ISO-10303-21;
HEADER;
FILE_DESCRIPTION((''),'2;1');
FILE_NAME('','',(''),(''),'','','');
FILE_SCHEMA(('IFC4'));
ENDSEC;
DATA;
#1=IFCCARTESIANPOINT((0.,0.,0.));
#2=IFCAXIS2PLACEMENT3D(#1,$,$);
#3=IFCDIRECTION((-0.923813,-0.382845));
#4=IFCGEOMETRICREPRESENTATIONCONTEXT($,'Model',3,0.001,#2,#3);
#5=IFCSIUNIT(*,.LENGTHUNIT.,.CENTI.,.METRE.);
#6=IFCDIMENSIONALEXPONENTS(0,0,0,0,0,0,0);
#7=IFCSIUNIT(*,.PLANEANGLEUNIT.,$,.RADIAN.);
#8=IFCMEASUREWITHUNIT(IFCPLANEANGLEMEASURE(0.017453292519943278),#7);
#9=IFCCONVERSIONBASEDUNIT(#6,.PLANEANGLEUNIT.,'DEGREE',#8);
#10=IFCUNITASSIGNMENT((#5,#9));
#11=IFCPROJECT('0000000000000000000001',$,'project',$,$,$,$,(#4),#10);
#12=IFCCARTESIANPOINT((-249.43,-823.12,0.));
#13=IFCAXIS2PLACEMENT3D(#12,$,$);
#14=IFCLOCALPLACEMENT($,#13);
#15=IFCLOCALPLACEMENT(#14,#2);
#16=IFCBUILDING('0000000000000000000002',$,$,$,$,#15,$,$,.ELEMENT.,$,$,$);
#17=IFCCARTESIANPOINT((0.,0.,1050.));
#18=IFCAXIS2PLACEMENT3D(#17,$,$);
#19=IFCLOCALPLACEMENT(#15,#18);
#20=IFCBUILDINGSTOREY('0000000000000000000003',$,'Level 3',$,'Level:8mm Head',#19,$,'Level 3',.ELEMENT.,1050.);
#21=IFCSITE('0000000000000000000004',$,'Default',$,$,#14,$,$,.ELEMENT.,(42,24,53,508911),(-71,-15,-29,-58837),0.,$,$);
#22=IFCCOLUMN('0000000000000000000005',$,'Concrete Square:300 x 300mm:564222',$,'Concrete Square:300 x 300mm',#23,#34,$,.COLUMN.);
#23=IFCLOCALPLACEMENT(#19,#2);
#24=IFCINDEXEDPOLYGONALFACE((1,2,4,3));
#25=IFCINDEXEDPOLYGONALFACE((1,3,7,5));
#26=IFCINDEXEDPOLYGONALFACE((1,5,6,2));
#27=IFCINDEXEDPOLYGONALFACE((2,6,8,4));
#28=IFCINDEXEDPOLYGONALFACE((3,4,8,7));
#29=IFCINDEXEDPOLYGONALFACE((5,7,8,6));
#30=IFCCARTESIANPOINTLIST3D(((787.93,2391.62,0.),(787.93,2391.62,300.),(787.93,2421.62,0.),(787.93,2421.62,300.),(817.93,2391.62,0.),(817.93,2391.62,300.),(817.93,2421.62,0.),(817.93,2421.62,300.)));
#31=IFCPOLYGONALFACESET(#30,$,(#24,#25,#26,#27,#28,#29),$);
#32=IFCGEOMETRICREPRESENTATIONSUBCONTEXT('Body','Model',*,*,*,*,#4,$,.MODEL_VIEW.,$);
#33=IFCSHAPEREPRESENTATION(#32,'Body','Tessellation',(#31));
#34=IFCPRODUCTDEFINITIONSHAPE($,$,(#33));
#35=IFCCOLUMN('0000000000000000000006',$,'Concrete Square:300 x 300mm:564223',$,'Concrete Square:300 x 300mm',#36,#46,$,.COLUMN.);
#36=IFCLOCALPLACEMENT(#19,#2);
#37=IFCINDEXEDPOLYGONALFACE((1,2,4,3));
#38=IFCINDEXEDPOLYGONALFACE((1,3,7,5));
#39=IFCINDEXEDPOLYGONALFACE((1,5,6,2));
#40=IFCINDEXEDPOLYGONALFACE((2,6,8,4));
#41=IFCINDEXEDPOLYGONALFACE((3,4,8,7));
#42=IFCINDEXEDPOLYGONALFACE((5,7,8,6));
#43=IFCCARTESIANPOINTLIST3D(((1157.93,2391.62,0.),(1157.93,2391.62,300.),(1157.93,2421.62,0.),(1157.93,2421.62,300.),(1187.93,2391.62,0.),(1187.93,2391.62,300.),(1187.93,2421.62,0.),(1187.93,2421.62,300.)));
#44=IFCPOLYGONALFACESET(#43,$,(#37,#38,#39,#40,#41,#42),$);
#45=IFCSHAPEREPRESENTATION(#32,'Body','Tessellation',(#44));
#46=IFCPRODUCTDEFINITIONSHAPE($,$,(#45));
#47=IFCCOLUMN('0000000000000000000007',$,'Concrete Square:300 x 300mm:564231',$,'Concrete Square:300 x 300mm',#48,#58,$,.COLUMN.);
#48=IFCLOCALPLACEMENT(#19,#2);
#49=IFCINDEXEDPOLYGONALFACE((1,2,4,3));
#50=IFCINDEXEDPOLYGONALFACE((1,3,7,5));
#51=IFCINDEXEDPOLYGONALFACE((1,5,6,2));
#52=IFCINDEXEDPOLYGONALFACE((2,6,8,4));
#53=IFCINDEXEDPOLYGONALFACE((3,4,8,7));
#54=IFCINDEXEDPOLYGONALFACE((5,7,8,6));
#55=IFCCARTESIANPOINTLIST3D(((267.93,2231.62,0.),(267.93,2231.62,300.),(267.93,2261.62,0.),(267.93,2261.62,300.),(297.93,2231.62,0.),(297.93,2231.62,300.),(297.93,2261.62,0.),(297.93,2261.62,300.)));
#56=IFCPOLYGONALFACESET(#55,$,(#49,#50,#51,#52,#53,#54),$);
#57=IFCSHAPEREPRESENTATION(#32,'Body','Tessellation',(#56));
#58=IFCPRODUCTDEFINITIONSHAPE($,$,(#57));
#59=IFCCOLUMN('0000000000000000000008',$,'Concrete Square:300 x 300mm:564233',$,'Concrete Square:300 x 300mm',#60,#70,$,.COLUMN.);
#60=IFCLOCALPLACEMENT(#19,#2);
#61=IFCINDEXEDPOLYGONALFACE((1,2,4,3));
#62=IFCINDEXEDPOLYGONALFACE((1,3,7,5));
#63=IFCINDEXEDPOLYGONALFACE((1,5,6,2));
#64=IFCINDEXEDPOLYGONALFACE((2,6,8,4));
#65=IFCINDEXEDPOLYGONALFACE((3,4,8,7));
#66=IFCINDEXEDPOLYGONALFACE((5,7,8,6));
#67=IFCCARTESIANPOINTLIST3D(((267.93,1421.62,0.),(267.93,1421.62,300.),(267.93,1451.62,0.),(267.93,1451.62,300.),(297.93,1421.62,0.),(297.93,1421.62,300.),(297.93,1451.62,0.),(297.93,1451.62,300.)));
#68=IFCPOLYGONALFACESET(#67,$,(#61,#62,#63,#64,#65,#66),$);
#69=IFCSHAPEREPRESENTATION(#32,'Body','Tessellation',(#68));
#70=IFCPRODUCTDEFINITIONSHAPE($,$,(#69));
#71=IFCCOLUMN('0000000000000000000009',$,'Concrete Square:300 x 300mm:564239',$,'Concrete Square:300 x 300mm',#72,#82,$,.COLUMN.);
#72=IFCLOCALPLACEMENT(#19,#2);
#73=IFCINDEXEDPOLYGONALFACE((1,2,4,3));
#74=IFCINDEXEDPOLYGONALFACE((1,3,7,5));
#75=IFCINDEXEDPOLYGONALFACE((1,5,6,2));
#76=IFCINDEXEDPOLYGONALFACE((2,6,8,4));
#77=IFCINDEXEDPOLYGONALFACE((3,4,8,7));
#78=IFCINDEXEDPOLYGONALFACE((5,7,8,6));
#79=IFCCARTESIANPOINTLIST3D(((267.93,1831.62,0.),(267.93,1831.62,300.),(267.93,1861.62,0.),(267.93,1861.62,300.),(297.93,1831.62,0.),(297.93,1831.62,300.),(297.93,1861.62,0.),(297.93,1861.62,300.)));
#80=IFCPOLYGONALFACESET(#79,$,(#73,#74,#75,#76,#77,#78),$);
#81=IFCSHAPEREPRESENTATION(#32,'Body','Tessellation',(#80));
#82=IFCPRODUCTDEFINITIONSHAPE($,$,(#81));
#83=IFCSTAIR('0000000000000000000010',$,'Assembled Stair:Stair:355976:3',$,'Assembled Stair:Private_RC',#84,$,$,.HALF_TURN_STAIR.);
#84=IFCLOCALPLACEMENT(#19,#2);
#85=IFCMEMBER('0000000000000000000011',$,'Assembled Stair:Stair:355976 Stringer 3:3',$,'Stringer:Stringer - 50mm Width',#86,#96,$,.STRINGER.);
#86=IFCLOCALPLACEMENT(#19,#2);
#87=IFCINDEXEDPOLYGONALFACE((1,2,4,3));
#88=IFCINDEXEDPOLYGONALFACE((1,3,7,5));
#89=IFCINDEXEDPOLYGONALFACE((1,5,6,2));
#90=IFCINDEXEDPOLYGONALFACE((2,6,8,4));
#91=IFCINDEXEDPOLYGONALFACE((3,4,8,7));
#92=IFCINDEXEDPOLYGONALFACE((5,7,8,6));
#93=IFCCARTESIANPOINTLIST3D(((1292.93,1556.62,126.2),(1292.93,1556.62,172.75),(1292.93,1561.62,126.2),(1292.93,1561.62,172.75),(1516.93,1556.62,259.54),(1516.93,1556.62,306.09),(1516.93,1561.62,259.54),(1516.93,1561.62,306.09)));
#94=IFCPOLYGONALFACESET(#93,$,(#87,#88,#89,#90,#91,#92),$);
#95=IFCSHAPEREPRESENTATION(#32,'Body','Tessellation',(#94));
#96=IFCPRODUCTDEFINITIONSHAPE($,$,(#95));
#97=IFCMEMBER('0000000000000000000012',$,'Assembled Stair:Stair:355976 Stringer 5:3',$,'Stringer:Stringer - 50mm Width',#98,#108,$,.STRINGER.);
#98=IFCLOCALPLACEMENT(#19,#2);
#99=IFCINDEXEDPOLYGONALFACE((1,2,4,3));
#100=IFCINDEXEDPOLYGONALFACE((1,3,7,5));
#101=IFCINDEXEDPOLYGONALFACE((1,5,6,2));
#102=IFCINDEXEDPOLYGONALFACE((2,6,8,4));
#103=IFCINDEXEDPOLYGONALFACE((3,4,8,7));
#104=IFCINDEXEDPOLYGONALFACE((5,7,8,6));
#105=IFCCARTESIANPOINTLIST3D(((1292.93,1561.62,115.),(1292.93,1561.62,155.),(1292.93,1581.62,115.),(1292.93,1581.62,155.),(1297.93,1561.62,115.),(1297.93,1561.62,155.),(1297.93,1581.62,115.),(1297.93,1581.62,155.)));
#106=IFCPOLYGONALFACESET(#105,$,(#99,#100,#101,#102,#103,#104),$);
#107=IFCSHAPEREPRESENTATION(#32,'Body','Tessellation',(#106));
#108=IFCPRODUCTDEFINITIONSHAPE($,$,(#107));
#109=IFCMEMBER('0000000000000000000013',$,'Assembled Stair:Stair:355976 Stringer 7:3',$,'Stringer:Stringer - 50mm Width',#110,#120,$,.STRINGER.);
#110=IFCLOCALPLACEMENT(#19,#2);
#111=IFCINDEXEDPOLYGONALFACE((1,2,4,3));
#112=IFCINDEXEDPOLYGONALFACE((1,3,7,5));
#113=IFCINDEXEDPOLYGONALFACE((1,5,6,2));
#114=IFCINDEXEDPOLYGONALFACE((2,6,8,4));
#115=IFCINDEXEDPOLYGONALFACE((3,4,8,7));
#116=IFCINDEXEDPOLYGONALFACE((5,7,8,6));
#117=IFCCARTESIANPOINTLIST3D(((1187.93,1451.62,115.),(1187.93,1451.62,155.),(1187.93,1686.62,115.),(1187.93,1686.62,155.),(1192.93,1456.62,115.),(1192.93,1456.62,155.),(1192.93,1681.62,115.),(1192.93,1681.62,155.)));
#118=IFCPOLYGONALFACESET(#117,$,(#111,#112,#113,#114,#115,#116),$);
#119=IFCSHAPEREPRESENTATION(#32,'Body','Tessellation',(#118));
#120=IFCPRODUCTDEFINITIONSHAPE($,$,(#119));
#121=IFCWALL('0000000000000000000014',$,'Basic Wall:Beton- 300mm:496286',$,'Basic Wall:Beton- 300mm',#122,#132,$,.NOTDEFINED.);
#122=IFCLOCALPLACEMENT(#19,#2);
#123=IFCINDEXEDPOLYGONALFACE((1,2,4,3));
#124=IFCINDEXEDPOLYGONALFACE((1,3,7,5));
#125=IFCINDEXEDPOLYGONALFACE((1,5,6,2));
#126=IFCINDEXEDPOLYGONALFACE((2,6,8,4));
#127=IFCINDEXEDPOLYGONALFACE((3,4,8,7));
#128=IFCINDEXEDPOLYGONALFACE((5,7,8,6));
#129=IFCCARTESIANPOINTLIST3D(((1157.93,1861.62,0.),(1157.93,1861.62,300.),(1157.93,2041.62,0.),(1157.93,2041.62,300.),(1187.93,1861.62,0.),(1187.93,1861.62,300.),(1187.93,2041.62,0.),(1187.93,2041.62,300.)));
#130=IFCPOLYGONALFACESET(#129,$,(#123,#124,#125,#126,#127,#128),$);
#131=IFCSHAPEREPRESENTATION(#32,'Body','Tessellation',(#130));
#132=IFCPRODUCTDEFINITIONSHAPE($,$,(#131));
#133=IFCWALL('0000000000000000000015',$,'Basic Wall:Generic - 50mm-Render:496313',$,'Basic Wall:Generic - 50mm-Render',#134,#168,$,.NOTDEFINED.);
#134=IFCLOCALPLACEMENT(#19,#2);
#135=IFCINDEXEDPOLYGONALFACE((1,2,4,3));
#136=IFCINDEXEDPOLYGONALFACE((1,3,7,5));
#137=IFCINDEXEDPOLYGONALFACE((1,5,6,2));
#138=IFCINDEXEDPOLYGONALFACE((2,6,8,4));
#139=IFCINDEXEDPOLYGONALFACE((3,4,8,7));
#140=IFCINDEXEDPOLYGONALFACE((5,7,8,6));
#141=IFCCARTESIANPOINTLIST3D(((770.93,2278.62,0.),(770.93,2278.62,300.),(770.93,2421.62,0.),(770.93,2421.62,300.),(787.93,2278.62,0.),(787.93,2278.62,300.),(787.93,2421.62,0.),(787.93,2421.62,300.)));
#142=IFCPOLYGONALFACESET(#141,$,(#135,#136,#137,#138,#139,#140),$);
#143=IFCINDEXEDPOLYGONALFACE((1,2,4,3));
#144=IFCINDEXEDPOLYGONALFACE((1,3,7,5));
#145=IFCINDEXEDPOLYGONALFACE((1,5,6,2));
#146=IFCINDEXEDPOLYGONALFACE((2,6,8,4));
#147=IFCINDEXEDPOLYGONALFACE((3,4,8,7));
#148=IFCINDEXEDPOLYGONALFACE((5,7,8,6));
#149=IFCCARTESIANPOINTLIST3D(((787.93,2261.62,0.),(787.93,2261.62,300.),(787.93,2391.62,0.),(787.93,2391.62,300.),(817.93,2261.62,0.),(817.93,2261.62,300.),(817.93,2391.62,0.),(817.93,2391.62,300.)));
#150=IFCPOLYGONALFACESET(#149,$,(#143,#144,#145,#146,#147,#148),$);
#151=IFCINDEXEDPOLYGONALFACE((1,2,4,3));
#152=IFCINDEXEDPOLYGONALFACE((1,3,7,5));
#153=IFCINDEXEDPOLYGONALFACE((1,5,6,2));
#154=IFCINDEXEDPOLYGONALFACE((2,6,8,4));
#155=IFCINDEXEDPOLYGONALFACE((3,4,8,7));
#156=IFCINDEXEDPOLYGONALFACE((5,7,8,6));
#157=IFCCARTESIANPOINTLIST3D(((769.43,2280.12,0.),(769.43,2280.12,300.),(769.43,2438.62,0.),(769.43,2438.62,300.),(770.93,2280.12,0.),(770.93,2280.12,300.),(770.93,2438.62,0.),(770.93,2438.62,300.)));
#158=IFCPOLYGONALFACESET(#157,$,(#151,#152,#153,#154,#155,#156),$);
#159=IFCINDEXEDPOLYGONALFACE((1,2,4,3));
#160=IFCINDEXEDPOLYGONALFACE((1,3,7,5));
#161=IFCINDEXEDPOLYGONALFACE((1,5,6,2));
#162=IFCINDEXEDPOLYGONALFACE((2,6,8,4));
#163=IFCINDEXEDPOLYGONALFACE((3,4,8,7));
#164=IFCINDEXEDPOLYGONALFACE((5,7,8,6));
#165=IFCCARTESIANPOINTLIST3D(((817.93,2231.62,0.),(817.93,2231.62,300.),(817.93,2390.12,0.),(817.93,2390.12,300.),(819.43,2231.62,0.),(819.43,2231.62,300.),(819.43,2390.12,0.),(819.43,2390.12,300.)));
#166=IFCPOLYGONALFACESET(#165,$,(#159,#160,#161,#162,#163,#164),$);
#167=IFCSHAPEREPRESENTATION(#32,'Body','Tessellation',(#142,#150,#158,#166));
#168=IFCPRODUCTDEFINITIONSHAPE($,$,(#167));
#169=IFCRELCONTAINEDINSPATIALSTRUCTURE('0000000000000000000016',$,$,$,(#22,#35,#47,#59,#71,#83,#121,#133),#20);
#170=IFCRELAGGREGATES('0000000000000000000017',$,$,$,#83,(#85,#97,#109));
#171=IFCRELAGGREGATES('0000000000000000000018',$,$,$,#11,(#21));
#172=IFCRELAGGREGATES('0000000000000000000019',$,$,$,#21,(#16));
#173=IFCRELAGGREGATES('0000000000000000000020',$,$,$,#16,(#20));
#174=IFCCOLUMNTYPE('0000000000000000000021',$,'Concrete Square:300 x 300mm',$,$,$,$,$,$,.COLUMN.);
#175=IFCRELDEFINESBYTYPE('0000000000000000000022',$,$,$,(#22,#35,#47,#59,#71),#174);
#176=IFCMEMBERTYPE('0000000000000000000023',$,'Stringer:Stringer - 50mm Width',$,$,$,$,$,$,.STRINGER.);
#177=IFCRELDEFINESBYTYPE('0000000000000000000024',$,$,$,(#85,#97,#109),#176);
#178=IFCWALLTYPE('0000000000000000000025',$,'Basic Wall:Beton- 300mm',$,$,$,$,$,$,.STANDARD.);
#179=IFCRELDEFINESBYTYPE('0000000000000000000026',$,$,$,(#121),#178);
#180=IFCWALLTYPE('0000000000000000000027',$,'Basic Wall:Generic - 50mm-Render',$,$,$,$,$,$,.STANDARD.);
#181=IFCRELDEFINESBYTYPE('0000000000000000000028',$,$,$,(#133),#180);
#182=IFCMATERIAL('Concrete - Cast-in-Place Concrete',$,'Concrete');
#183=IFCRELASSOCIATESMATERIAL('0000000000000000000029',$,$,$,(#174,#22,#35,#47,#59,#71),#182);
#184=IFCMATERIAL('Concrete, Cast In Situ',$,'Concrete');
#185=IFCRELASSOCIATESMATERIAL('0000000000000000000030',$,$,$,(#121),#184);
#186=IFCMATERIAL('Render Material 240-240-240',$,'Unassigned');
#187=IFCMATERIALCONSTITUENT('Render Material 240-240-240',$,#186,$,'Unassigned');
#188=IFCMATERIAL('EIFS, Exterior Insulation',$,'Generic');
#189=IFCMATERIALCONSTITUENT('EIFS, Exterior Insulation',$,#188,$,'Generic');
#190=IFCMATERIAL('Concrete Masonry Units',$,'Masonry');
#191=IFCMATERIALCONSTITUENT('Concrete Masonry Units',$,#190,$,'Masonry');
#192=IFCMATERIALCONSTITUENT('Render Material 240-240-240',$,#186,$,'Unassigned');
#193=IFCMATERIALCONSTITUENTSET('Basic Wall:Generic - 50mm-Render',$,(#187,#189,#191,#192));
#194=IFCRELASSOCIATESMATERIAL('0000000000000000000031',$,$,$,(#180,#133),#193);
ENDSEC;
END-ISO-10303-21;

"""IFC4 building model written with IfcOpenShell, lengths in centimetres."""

from ifc_helpers import new_model, entity, si_unit, converted_unit, direction, frame, origin, place, context, subcontext, project, spatial, indexed_curve, outline, extrude, source, transform, mapped, material, constituent, constituent_set, type_object, type_shapes, element, aggregate, save


model = new_model("IFC4")

# Units and contexts
model_context = context("Model", 3, precision=0.001, world=origin(), true_north=direction((-0.923813, -0.382845)))
body_context = subcontext(model_context, "Body", "Model", "MODEL_VIEW")
ifc_project = project(units=[si_unit("LENGTHUNIT", "METRE", prefix="CENTI"), converted_unit("PLANEANGLEUNIT", "DEGREE", entity("IfcPlaneAngleMeasure", 0.017453292519943278), si_unit("PLANEANGLEUNIT", "RADIAN"), dimensions=[0, 0, 0, 0, 0, 0, 0])], contexts=[model_context])

# Site, building, storey
site_placement = place(None, frame((-249.43, -823.12, 0.0)))
site = spatial("IfcSite", under=ifc_project, at=site_placement, Name="Default", CompositionType="ELEMENT", RefLatitude=(42, 24, 53, 508911), RefLongitude=(-71, -15, -29, -58837), RefElevation=0.0)
building_placement = place(site_placement, origin())
building = spatial("IfcBuilding", under=site, at=building_placement, CompositionType="ELEMENT")
storey_placement = place(building_placement, frame((0.0, 0.0, 1050.0)))
storey = spatial("IfcBuildingStorey", under=building, at=storey_placement, Name="Level 3", ObjectType="Level:8mm Head", LongName="Level 3", CompositionType="ELEMENT", Elevation=1050.0)

# Columns
ifc_material_1 = material(Name="Concrete - Cast-in-Place Concrete", Category="Concrete")
column_type = type_object("IfcColumnType", Name="Concrete Square:300 x 300mm", PredefinedType="COLUMN", material=ifc_material_1)
shared_shape_1 = source(origin(), body_context, "Body", "SweptSolid", [
    extrude(outline(indexed_curve([(-15.0, -15.0), (15.0, -15.0), (15.0, 15.0), (-15.0, 15.0), (-15.0, -15.0)], self_intersect=False)), frame((0.0, 0.0, 1050.0), z_axis=(0.0, 0.0, 1.0), x_axis=(-1.0, 0.0, 0.0)), (0.0, 0.0, 1.0), 300.0),
])
type_shapes(column_type, [shared_shape_1])
for number, where, name in (
    (1, (802.93, 2406.62, -1050.0), "Concrete Square:300 x 300mm:564222"),
    (2, (1172.93, 2406.62, -1050.0), "Concrete Square:300 x 300mm:564223"),
    (3, (282.93, 2246.62, -1050.0), "Concrete Square:300 x 300mm:564231"),
    (4, (282.93, 1436.62, -1050.0), "Concrete Square:300 x 300mm:564233"),
    (5, (282.93, 1846.62, -1050.0), "Concrete Square:300 x 300mm:564239"),
):
    element("IfcColumn", number, at=place(storey_placement, frame(where)), inside=storey, type_object=column_type, material=ifc_material_1, Name=name, ObjectType="Concrete Square:300 x 300mm", PredefinedType="COLUMN", context=body_context, shape_type="MappedRepresentation", body=[
        mapped(shared_shape_1, transform((0.0, 0.0, 0.0), scale=1.0)),
    ])

# Stair, members
stair_placement = place(storey_placement, origin())
stair = element("IfcStair", 6, at=stair_placement, inside=storey, Name="Assembled Stair:Stair:355976:3", ObjectType="Assembled Stair:Private_RC", PredefinedType="HALF_TURN_STAIR")
member_type = type_object("IfcMemberType", Name="Stringer:Stringer - 50mm Width", PredefinedType="STRINGER")
member_1_placement = place(stair_placement, frame((1292.93, 1556.62, 126.2)))
member_1 = element("IfcMember", 7, at=member_1_placement, type_object=member_type, Name="Assembled Stair:Stair:355976 Stringer 3:3", ObjectType="Stringer:Stringer - 50mm Width", PredefinedType="STRINGER", context=body_context, shape_type="SweptSolid", body=[
    extrude(outline(indexed_curve([(-118.43, -20.0), (142.24, -20.0), (118.43, 20.0), (-142.24, 20.0), (-118.43, -20.0)], self_intersect=False)), frame((112.0, 0.0, 89.94), z_axis=(0.0, 1.0, 0.0), x_axis=(0.859293, 0.0, 0.511484)), (0.0, 0.0, 1.0), 5.0),
])
member_2_placement = place(stair_placement, frame((1292.93, 1561.62, 115.0)))
member_2 = element("IfcMember", 8, at=member_2_placement, type_object=member_type, Name="Assembled Stair:Stair:355976 Stringer 5:3", ObjectType="Stringer:Stringer - 50mm Width", PredefinedType="STRINGER", context=body_context, shape_type="SweptSolid", body=[
    extrude(outline(indexed_curve([(-10.0, -2.5), (10.0, -2.5), (10.0, 2.5), (-10.0, 2.5), (-10.0, -2.5)], self_intersect=False)), frame((2.5, 10.0, 0.0), z_axis=(0.0, 0.0, 1.0), x_axis=(0.0, 1.0, 0.0)), (0.0, 0.0, 1.0), 40.0),
])
member_3_placement = place(stair_placement, frame((1187.93, 1451.62, 115.0)))
member_3 = element("IfcMember", 9, at=member_3_placement, type_object=member_type, Name="Assembled Stair:Stair:355976 Stringer 7:3", ObjectType="Stringer:Stringer - 50mm Width", PredefinedType="STRINGER", context=body_context, shape_type="SweptSolid", body=[
    extrude(outline(indexed_curve([(-117.5, -2.5), (117.5, -2.5), (112.5, 2.5), (-112.5, 2.5), (-117.5, -2.5)], self_intersect=False)), frame((2.5, 117.5, 0.0), z_axis=(0.0, 0.0, 1.0), x_axis=(0.0, -1.0, 0.0)), (0.0, 0.0, 1.0), 40.0),
])

# Walls
ifc_material_2 = material(Name="Concrete, Cast In Situ", Category="Concrete")
wall_type_1 = type_object("IfcWallType", Name="Basic Wall:Beton- 300mm", PredefinedType="STANDARD")
wall_1_placement = place(storey_placement, frame((1172.93, 2041.62, 0.0), z_axis=(0.0, 0.0, 1.0), x_axis=(0.0, -1.0, 0.0)))
element("IfcWall", 10, at=wall_1_placement, inside=storey, type_object=wall_type_1, material=ifc_material_2, Name="Basic Wall:Beton- 300mm:496286", ObjectType="Basic Wall:Beton- 300mm", PredefinedType="NOTDEFINED", context=body_context, shape_type="SweptSolid", body=[
    extrude(outline(indexed_curve([(180.0, 15.0), (0.0, 15.0), (0.0, -15.0), (180.0, -15.0), (180.0, 15.0)], self_intersect=False)), origin(), (0.0, 0.0, 1.0), 300.0),
])
ifc_material_3 = material(Name="Render Material 240-240-240", Category="Unassigned")
ifc_constituent_1 = constituent(ifc_material_3, Name="Render Material 240-240-240", Category="Unassigned")
ifc_material_4 = material(Name="EIFS, Exterior Insulation", Category="Generic")
ifc_constituent_2 = constituent(ifc_material_4, Name="EIFS, Exterior Insulation", Category="Generic")
ifc_material_5 = material(Name="Concrete Masonry Units", Category="Masonry")
ifc_constituent_3 = constituent(ifc_material_5, Name="Concrete Masonry Units", Category="Masonry")
ifc_constituent_4 = constituent(ifc_material_3, Name="Render Material 240-240-240", Category="Unassigned")
ifc_constituent_set_1 = constituent_set(constituents=[ifc_constituent_1, ifc_constituent_2, ifc_constituent_3, ifc_constituent_4], Name="Basic Wall:Generic - 50mm-Render")
wall_type_2 = type_object("IfcWallType", Name="Basic Wall:Generic - 50mm-Render", PredefinedType="STANDARD", material=ifc_constituent_set_1)
wall_2_placement = place(storey_placement, frame((794.43, 2280.12, 0.0), z_axis=(0.0, 0.0, 1.0), x_axis=(0.0, 1.0, 0.0)))
element("IfcWall", 11, at=wall_2_placement, inside=storey, type_object=wall_type_2, material=ifc_constituent_set_1, Name="Basic Wall:Generic - 50mm-Render:496313", ObjectType="Basic Wall:Generic - 50mm-Render", PredefinedType="NOTDEFINED", context=body_context, shape_type="SweptSolid", body=[
    extrude(outline(indexed_curve([(-8.5, -71.5), (8.5, -71.5), (8.5, 71.5), (-8.5, 71.5), (-8.5, -71.5)], self_intersect=False)), frame((70.0, 15.0, 0.0), z_axis=(0.0, 0.0, 1.0), x_axis=(0.0, -1.0, 0.0)), (0.0, 0.0, 1.0), 300.0),
    extrude(outline(indexed_curve([(-15.0, -65.0), (15.0, -65.0), (15.0, 65.0), (-15.0, 65.0), (-15.0, -65.0)], self_intersect=False)), frame((46.5, -8.5, 0.0), z_axis=(0.0, 0.0, 1.0), x_axis=(0.0, 1.0, 0.0)), (0.0, 0.0, 1.0), 300.0),
    extrude(outline(indexed_curve([(-0.75, -79.25), (0.75, -79.25), (0.75, 79.25), (-0.75, 79.25), (-0.75, -79.25)], self_intersect=False)), frame((79.25, 24.25, 0.0), z_axis=(0.0, 0.0, 1.0), x_axis=(0.0, -1.0, 0.0)), (0.0, 0.0, 1.0), 300.0),
    extrude(outline(indexed_curve([(-0.75, -79.25), (0.75, -79.25), (0.75, 79.25), (-0.75, 79.25), (-0.75, -79.25)], self_intersect=False)), frame((30.75, -24.25, 0.0), z_axis=(0.0, 0.0, 1.0), x_axis=(0.0, -1.0, 0.0)), (0.0, 0.0, 1.0), 300.0),
])

aggregate(stair, [member_1, member_2, member_3])

save(model, "model.ifc")
